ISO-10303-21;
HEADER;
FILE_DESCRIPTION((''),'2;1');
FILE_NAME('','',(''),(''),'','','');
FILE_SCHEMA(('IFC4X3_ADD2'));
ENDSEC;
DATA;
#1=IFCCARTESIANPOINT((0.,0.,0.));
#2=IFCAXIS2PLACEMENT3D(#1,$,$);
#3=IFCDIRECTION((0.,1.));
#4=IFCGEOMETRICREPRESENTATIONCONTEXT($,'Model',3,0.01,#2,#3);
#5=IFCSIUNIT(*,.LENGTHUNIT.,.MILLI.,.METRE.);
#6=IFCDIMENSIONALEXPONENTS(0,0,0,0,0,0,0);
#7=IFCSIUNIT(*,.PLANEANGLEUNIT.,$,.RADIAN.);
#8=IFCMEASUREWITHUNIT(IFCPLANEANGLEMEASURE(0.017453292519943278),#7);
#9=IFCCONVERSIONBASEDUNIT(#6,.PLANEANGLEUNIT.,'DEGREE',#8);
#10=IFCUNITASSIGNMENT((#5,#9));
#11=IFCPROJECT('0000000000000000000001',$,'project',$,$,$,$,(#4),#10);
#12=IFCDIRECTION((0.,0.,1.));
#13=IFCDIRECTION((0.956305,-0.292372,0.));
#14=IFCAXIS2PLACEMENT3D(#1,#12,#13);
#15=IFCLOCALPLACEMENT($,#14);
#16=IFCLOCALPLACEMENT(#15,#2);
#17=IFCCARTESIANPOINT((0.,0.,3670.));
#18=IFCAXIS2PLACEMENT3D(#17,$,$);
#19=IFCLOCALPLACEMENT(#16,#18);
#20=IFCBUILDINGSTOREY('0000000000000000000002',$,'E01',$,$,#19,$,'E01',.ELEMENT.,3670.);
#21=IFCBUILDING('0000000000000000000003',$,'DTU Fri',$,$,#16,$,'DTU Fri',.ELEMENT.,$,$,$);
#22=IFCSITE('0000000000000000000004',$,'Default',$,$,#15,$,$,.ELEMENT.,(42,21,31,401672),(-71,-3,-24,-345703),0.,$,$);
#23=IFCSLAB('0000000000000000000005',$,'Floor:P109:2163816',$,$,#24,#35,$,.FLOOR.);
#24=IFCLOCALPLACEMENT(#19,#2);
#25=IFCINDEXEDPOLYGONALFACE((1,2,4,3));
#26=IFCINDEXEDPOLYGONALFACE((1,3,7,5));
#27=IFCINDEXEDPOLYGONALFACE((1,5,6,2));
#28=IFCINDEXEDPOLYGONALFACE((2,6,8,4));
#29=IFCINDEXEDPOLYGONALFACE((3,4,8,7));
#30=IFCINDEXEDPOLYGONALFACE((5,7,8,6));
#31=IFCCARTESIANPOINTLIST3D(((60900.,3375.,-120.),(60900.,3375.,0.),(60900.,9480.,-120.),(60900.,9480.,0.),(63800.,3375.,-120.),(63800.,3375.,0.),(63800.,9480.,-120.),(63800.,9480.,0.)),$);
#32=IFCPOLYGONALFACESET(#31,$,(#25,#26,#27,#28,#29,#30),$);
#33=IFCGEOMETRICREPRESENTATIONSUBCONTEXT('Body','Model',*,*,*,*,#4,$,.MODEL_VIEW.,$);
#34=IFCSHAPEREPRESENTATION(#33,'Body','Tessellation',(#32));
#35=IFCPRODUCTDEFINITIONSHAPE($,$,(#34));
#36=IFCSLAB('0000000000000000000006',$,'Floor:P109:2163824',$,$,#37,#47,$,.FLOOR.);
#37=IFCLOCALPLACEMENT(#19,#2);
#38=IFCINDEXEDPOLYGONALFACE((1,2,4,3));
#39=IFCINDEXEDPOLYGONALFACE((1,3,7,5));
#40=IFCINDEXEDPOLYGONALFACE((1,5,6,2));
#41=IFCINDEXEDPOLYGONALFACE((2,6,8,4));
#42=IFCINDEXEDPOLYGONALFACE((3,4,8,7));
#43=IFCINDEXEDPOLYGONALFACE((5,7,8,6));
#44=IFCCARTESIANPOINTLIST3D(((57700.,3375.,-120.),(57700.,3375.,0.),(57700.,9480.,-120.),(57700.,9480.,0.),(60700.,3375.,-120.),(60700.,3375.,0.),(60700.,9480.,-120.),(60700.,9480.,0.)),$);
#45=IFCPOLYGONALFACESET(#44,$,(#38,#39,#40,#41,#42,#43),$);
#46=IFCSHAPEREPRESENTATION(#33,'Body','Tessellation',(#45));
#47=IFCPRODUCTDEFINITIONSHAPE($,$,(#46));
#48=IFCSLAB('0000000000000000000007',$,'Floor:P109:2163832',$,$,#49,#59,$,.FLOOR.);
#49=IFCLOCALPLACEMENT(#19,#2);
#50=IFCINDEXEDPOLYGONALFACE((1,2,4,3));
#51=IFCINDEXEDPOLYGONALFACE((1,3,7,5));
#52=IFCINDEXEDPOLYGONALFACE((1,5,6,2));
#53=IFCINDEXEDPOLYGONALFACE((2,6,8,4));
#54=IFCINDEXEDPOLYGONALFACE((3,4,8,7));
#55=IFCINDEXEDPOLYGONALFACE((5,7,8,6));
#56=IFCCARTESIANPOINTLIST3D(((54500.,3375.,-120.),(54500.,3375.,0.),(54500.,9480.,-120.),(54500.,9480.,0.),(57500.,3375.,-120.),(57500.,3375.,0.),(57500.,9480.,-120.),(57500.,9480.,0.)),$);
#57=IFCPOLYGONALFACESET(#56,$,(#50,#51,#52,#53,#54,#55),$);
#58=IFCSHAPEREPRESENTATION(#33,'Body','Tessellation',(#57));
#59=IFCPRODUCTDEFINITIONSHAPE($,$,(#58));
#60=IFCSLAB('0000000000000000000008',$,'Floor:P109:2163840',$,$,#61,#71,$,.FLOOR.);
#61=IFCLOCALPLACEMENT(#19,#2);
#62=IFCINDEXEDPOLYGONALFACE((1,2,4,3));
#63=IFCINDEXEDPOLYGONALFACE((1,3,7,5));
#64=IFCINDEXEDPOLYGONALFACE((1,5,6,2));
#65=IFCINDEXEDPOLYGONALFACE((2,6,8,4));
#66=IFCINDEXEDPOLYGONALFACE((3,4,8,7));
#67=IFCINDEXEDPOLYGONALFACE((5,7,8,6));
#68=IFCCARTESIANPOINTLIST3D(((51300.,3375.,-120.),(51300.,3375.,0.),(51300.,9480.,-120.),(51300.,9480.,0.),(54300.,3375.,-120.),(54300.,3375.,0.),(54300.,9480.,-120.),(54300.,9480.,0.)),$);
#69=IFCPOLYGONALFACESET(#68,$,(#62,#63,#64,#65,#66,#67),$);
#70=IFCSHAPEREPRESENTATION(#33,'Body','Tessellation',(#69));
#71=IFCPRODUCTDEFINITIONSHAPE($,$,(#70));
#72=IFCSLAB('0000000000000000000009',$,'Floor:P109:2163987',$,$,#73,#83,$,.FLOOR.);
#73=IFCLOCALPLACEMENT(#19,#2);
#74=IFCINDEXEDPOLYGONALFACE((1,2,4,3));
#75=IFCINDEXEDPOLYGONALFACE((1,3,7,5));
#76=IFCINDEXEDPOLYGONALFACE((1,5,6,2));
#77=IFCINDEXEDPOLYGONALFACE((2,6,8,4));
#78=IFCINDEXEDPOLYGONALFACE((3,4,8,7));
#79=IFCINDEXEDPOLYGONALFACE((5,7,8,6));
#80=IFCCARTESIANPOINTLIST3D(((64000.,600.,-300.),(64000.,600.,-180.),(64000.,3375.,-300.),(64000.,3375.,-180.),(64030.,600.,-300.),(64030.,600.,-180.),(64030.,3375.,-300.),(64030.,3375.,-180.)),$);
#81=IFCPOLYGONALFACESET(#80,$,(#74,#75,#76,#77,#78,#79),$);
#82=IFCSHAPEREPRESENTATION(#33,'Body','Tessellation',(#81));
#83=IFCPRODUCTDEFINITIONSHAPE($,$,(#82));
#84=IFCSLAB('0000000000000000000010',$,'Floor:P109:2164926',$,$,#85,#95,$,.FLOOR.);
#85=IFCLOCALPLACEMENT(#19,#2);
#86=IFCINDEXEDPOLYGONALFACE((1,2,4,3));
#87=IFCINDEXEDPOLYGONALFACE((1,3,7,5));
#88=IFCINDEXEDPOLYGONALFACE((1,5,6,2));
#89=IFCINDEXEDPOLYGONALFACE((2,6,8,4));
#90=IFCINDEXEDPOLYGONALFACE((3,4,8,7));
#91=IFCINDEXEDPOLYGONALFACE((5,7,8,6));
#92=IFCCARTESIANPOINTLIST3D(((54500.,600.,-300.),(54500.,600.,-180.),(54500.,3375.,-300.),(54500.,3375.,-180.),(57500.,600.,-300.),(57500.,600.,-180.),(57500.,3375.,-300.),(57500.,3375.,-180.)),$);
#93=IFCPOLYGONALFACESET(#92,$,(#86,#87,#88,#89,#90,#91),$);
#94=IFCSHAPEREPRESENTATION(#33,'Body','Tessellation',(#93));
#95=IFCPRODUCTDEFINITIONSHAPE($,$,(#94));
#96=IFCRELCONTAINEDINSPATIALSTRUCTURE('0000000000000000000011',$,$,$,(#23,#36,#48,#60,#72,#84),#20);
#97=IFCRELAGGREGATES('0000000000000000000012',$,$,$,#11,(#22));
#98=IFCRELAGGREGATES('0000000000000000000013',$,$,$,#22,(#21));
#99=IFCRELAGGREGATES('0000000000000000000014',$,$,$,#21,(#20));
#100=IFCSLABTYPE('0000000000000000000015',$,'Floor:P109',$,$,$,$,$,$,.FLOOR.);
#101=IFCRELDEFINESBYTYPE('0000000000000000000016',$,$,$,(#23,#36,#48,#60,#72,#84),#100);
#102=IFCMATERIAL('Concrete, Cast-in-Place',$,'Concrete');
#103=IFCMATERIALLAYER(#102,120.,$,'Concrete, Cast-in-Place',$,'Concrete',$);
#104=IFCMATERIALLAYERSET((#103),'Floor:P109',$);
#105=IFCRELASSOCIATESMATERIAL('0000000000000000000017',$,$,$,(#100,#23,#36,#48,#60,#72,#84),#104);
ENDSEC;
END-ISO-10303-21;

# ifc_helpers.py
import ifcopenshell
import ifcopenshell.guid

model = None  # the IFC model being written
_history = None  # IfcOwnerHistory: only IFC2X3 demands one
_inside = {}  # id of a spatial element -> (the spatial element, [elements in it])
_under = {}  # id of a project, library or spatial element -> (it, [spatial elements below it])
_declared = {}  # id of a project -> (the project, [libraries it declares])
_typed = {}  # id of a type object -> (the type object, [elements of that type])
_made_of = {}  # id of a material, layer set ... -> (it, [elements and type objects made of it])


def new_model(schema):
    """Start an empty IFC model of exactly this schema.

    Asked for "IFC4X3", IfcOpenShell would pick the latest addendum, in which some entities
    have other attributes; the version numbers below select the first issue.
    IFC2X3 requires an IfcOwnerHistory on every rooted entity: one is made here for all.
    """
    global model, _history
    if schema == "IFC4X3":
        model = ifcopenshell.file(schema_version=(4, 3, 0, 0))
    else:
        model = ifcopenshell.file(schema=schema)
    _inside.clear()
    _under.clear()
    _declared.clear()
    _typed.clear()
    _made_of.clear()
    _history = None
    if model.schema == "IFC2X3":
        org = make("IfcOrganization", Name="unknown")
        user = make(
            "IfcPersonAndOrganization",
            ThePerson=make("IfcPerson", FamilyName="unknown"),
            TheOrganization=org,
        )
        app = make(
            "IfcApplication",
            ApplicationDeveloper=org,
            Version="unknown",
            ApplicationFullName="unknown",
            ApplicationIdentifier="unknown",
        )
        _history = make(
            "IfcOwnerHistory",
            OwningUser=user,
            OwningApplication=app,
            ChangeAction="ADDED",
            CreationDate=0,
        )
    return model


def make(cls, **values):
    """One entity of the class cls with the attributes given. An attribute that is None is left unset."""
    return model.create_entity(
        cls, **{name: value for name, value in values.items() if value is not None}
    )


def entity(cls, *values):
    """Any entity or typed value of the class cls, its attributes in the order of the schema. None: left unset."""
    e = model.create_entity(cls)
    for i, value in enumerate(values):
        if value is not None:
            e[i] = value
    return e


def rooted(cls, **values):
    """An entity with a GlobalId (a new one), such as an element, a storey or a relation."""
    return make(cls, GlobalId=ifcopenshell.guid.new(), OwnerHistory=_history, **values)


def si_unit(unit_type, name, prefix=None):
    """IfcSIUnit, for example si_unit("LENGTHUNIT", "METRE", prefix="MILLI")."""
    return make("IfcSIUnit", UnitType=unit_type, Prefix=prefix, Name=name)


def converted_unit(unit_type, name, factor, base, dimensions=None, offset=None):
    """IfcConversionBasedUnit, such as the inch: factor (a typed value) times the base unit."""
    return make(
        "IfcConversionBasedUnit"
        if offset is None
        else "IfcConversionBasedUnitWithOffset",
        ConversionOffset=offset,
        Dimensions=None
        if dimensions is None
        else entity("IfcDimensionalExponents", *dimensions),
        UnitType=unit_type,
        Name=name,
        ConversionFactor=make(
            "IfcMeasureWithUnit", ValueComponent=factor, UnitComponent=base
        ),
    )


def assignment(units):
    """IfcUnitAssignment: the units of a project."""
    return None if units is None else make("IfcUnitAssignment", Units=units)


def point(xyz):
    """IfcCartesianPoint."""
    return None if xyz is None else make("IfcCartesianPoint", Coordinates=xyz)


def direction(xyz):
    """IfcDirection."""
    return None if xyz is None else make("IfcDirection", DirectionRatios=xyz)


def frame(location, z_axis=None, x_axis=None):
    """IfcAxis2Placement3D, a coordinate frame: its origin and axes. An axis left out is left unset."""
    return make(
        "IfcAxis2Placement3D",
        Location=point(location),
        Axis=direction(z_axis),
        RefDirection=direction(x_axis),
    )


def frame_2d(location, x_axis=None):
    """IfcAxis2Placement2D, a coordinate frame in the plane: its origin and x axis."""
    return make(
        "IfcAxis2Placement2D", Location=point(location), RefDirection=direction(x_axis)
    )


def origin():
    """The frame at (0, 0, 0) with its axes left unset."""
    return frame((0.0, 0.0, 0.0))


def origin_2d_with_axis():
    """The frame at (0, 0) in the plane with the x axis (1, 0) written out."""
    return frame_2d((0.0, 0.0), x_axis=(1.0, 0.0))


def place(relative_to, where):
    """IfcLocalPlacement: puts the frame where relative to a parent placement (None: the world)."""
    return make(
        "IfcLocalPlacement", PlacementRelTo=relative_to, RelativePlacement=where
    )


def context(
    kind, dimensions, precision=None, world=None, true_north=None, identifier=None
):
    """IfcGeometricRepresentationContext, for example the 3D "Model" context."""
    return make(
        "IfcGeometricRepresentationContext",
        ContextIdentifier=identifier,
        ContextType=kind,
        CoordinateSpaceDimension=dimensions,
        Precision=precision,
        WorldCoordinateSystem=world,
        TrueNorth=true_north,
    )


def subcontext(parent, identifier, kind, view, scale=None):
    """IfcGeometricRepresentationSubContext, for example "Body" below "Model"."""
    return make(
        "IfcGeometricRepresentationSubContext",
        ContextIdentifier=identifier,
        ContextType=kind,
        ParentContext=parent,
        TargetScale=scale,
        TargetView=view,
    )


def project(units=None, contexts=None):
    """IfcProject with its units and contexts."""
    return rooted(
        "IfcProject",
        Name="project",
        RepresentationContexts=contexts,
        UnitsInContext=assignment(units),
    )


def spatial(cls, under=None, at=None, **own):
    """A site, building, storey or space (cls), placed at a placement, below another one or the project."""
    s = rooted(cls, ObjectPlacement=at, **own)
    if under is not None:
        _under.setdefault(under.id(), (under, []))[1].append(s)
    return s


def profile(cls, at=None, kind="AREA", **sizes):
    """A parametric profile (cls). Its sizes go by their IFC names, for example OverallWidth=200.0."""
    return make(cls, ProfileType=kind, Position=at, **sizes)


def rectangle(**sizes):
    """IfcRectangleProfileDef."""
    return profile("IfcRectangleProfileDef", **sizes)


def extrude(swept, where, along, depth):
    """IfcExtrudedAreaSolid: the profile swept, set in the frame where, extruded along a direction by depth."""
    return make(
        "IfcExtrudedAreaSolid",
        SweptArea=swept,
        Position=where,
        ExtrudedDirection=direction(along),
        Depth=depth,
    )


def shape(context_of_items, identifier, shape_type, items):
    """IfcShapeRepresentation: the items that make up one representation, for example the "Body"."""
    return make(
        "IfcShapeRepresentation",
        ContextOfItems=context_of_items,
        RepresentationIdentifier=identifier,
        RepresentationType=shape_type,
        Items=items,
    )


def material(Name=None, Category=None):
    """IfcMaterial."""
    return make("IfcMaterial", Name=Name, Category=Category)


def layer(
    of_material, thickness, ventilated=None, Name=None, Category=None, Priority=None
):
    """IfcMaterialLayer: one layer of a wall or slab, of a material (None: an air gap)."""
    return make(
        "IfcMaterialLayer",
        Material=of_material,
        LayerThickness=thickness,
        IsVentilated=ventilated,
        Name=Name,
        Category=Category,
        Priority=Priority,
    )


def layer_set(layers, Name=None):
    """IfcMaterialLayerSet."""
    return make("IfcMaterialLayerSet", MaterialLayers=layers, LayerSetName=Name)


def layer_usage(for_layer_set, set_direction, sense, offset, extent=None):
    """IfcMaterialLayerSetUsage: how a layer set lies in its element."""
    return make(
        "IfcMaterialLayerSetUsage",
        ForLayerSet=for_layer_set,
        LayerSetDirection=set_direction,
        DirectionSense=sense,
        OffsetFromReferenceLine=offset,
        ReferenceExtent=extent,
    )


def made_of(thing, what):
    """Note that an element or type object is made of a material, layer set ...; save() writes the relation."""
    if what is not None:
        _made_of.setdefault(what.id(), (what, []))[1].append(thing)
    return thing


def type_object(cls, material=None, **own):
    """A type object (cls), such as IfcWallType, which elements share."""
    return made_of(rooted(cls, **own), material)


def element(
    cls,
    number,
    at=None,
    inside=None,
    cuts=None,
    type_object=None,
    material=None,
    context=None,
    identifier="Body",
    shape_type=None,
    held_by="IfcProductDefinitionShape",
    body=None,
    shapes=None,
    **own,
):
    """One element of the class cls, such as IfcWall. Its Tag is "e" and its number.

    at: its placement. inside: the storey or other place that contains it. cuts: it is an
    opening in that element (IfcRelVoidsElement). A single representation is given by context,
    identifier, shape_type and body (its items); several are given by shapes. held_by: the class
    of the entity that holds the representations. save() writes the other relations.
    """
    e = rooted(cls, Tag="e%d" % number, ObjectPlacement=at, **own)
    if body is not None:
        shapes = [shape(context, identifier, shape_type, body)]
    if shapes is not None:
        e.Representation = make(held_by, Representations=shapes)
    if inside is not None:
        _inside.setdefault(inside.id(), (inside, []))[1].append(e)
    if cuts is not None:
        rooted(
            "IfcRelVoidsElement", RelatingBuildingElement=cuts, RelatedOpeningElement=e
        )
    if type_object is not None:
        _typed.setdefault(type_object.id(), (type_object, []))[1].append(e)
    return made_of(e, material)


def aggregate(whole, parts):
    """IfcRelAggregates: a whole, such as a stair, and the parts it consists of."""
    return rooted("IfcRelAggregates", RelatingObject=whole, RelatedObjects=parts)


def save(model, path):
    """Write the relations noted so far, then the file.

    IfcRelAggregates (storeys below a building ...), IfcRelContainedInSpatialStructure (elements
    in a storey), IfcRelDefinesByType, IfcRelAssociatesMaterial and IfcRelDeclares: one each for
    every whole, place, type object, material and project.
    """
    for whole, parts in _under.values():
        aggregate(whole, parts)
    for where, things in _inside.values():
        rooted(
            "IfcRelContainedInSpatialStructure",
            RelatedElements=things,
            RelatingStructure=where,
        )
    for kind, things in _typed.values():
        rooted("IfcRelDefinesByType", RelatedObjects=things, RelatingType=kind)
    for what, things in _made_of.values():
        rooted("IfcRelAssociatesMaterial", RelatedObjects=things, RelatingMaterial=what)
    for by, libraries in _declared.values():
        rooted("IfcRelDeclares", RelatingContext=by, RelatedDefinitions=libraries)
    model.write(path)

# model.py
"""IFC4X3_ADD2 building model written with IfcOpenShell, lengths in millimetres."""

from ifc_helpers import new_model, entity, si_unit, converted_unit, direction, frame, frame_2d, origin, origin_2d_with_axis, place, context, subcontext, project, spatial, rectangle, extrude, material, layer, layer_set, layer_usage, type_object, element, save


model = new_model("IFC4X3_ADD2")

# Units and contexts
model_context = context("Model", 3, precision=0.01, world=origin(), true_north=direction((0.0, 1.0)))
body_context = subcontext(model_context, "Body", "Model", "MODEL_VIEW")
ifc_project = project(units=[si_unit("LENGTHUNIT", "METRE", prefix="MILLI"), converted_unit("PLANEANGLEUNIT", "DEGREE", entity("IfcPlaneAngleMeasure", 0.017453292519943278), si_unit("PLANEANGLEUNIT", "RADIAN"), dimensions=[0, 0, 0, 0, 0, 0, 0])], contexts=[model_context])

# Site, building, storey
site_placement = place(None, frame((0.0, 0.0, 0.0), z_axis=(0.0, 0.0, 1.0), x_axis=(0.956305, -0.292372, 0.0)))
site = spatial("IfcSite", under=ifc_project, at=site_placement, Name="Default", CompositionType="ELEMENT", RefLatitude=(42, 21, 31, 401672), RefLongitude=(-71, -3, -24, -345703), RefElevation=0.0)
building_placement = place(site_placement, origin())
building = spatial("IfcBuilding", under=site, at=building_placement, Name="DTU Fri", LongName="DTU Fri", CompositionType="ELEMENT")
storey_placement = place(building_placement, frame((0.0, 0.0, 3670.0)))
storey = spatial("IfcBuildingStorey", under=building, at=storey_placement, Name="E01", LongName="E01", CompositionType="ELEMENT", Elevation=3670.0)

# Slabs
ifc_material = material(Name="Concrete, Cast-in-Place", Category="Concrete")
ifc_layer_1 = layer(ifc_material, 120.0, Name="Concrete, Cast-in-Place", Category="Concrete")
ifc_layer_set_1 = layer_set([ifc_layer_1], Name="Floor:P109")
slab_type_1 = type_object("IfcSlabType", Name="Floor:P109", PredefinedType="FLOOR", material=ifc_layer_set_1)
ifc_layer_usage_1 = layer_usage(ifc_layer_set_1, "AXIS3", "POSITIVE", 0.0)
slab_1_placement = place(storey_placement, origin())
element("IfcSlab", 1, at=slab_1_placement, inside=storey, type_object=slab_type_1, material=ifc_layer_usage_1, Name="Floor:P109:2163816", PredefinedType="FLOOR", context=body_context, shape_type="SweptSolid", body=[
    extrude(rectangle(XDim=6105.0, YDim=2900.0, at=frame_2d((0.0, 0.0), x_axis=(1.0, 0.0))), frame((62350.0, 6427.5, 0.0), z_axis=(0.0, 0.0, -1.0), x_axis=(0.0, 1.0, 0.0)), (0.0, 0.0, 1.0), 120.0),
])
ifc_layer_usage_2 = layer_usage(ifc_layer_set_1, "AXIS3", "POSITIVE", 0.0)
slab_2_placement = place(storey_placement, origin())
element("IfcSlab", 2, at=slab_2_placement, inside=storey, type_object=slab_type_1, material=ifc_layer_usage_2, Name="Floor:P109:2163824", PredefinedType="FLOOR", context=body_context, shape_type="SweptSolid", body=[
    extrude(rectangle(XDim=6105.0, YDim=3000.0, at=origin_2d_with_axis()), frame((59200.0, 6427.5, 0.0), z_axis=(0.0, 0.0, -1.0), x_axis=(0.0, 1.0, 0.0)), (0.0, 0.0, 1.0), 120.0),
])
ifc_layer_usage_3 = layer_usage(ifc_layer_set_1, "AXIS3", "POSITIVE", 0.0)
slab_3_placement = place(storey_placement, origin())
element("IfcSlab", 3, at=slab_3_placement, inside=storey, type_object=slab_type_1, material=ifc_layer_usage_3, Name="Floor:P109:2163832", PredefinedType="FLOOR", context=body_context, shape_type="SweptSolid", body=[
    extrude(rectangle(XDim=6105.0, YDim=3000.0, at=frame_2d((0.0, 0.0), x_axis=(1.0, 0.0))), frame((56000.0, 6427.5, 0.0), z_axis=(0.0, 0.0, -1.0), x_axis=(0.0, 1.0, 0.0)), (0.0, 0.0, 1.0), 120.0),
])
ifc_layer_usage_4 = layer_usage(ifc_layer_set_1, "AXIS3", "POSITIVE", 0.0)
slab_4_placement = place(storey_placement, origin())
element("IfcSlab", 4, at=slab_4_placement, inside=storey, type_object=slab_type_1, material=ifc_layer_usage_4, Name="Floor:P109:2163840", PredefinedType="FLOOR", context=body_context, shape_type="SweptSolid", body=[
    extrude(rectangle(XDim=6105.0, YDim=3000.0, at=frame_2d((0.0, 0.0), x_axis=(1.0, 0.0))), frame((52800.0, 6427.5, 0.0), z_axis=(0.0, 0.0, -1.0), x_axis=(0.0, 1.0, 0.0)), (0.0, 0.0, 1.0), 120.0),
])
ifc_layer_usage_5 = layer_usage(ifc_layer_set_1, "AXIS3", "POSITIVE", 0.0)
slab_5_placement = place(storey_placement, origin())
element("IfcSlab", 5, at=slab_5_placement, inside=storey, type_object=slab_type_1, material=ifc_layer_usage_5, Name="Floor:P109:2163987", PredefinedType="FLOOR", context=body_context, shape_type="SweptSolid", body=[
    extrude(rectangle(XDim=2775.0, YDim=30.0, at=frame_2d((0.0, 0.0), x_axis=(1.0, 0.0))), frame((64015.0, 1987.5, -180.0), z_axis=(0.0, 0.0, -1.0), x_axis=(0.0, 1.0, 0.0)), (0.0, 0.0, 1.0), 120.0),
])
ifc_layer_usage_6 = layer_usage(ifc_layer_set_1, "AXIS3", "POSITIVE", 0.0)
slab_6_placement = place(storey_placement, origin())
element("IfcSlab", 6, at=slab_6_placement, inside=storey, type_object=slab_type_1, material=ifc_layer_usage_6, Name="Floor:P109:2164926", PredefinedType="FLOOR", context=body_context, shape_type="SweptSolid", body=[
    extrude(rectangle(XDim=2775.0, YDim=3000.0, at=frame_2d((0.0, 0.0), x_axis=(1.0, 0.0))), frame((56000.0, 1987.5, -180.0), z_axis=(0.0, 0.0, -1.0), x_axis=(0.0, 1.0, 0.0)), (0.0, 0.0, 1.0), 120.0),
])

save(model, "model.ifc")
